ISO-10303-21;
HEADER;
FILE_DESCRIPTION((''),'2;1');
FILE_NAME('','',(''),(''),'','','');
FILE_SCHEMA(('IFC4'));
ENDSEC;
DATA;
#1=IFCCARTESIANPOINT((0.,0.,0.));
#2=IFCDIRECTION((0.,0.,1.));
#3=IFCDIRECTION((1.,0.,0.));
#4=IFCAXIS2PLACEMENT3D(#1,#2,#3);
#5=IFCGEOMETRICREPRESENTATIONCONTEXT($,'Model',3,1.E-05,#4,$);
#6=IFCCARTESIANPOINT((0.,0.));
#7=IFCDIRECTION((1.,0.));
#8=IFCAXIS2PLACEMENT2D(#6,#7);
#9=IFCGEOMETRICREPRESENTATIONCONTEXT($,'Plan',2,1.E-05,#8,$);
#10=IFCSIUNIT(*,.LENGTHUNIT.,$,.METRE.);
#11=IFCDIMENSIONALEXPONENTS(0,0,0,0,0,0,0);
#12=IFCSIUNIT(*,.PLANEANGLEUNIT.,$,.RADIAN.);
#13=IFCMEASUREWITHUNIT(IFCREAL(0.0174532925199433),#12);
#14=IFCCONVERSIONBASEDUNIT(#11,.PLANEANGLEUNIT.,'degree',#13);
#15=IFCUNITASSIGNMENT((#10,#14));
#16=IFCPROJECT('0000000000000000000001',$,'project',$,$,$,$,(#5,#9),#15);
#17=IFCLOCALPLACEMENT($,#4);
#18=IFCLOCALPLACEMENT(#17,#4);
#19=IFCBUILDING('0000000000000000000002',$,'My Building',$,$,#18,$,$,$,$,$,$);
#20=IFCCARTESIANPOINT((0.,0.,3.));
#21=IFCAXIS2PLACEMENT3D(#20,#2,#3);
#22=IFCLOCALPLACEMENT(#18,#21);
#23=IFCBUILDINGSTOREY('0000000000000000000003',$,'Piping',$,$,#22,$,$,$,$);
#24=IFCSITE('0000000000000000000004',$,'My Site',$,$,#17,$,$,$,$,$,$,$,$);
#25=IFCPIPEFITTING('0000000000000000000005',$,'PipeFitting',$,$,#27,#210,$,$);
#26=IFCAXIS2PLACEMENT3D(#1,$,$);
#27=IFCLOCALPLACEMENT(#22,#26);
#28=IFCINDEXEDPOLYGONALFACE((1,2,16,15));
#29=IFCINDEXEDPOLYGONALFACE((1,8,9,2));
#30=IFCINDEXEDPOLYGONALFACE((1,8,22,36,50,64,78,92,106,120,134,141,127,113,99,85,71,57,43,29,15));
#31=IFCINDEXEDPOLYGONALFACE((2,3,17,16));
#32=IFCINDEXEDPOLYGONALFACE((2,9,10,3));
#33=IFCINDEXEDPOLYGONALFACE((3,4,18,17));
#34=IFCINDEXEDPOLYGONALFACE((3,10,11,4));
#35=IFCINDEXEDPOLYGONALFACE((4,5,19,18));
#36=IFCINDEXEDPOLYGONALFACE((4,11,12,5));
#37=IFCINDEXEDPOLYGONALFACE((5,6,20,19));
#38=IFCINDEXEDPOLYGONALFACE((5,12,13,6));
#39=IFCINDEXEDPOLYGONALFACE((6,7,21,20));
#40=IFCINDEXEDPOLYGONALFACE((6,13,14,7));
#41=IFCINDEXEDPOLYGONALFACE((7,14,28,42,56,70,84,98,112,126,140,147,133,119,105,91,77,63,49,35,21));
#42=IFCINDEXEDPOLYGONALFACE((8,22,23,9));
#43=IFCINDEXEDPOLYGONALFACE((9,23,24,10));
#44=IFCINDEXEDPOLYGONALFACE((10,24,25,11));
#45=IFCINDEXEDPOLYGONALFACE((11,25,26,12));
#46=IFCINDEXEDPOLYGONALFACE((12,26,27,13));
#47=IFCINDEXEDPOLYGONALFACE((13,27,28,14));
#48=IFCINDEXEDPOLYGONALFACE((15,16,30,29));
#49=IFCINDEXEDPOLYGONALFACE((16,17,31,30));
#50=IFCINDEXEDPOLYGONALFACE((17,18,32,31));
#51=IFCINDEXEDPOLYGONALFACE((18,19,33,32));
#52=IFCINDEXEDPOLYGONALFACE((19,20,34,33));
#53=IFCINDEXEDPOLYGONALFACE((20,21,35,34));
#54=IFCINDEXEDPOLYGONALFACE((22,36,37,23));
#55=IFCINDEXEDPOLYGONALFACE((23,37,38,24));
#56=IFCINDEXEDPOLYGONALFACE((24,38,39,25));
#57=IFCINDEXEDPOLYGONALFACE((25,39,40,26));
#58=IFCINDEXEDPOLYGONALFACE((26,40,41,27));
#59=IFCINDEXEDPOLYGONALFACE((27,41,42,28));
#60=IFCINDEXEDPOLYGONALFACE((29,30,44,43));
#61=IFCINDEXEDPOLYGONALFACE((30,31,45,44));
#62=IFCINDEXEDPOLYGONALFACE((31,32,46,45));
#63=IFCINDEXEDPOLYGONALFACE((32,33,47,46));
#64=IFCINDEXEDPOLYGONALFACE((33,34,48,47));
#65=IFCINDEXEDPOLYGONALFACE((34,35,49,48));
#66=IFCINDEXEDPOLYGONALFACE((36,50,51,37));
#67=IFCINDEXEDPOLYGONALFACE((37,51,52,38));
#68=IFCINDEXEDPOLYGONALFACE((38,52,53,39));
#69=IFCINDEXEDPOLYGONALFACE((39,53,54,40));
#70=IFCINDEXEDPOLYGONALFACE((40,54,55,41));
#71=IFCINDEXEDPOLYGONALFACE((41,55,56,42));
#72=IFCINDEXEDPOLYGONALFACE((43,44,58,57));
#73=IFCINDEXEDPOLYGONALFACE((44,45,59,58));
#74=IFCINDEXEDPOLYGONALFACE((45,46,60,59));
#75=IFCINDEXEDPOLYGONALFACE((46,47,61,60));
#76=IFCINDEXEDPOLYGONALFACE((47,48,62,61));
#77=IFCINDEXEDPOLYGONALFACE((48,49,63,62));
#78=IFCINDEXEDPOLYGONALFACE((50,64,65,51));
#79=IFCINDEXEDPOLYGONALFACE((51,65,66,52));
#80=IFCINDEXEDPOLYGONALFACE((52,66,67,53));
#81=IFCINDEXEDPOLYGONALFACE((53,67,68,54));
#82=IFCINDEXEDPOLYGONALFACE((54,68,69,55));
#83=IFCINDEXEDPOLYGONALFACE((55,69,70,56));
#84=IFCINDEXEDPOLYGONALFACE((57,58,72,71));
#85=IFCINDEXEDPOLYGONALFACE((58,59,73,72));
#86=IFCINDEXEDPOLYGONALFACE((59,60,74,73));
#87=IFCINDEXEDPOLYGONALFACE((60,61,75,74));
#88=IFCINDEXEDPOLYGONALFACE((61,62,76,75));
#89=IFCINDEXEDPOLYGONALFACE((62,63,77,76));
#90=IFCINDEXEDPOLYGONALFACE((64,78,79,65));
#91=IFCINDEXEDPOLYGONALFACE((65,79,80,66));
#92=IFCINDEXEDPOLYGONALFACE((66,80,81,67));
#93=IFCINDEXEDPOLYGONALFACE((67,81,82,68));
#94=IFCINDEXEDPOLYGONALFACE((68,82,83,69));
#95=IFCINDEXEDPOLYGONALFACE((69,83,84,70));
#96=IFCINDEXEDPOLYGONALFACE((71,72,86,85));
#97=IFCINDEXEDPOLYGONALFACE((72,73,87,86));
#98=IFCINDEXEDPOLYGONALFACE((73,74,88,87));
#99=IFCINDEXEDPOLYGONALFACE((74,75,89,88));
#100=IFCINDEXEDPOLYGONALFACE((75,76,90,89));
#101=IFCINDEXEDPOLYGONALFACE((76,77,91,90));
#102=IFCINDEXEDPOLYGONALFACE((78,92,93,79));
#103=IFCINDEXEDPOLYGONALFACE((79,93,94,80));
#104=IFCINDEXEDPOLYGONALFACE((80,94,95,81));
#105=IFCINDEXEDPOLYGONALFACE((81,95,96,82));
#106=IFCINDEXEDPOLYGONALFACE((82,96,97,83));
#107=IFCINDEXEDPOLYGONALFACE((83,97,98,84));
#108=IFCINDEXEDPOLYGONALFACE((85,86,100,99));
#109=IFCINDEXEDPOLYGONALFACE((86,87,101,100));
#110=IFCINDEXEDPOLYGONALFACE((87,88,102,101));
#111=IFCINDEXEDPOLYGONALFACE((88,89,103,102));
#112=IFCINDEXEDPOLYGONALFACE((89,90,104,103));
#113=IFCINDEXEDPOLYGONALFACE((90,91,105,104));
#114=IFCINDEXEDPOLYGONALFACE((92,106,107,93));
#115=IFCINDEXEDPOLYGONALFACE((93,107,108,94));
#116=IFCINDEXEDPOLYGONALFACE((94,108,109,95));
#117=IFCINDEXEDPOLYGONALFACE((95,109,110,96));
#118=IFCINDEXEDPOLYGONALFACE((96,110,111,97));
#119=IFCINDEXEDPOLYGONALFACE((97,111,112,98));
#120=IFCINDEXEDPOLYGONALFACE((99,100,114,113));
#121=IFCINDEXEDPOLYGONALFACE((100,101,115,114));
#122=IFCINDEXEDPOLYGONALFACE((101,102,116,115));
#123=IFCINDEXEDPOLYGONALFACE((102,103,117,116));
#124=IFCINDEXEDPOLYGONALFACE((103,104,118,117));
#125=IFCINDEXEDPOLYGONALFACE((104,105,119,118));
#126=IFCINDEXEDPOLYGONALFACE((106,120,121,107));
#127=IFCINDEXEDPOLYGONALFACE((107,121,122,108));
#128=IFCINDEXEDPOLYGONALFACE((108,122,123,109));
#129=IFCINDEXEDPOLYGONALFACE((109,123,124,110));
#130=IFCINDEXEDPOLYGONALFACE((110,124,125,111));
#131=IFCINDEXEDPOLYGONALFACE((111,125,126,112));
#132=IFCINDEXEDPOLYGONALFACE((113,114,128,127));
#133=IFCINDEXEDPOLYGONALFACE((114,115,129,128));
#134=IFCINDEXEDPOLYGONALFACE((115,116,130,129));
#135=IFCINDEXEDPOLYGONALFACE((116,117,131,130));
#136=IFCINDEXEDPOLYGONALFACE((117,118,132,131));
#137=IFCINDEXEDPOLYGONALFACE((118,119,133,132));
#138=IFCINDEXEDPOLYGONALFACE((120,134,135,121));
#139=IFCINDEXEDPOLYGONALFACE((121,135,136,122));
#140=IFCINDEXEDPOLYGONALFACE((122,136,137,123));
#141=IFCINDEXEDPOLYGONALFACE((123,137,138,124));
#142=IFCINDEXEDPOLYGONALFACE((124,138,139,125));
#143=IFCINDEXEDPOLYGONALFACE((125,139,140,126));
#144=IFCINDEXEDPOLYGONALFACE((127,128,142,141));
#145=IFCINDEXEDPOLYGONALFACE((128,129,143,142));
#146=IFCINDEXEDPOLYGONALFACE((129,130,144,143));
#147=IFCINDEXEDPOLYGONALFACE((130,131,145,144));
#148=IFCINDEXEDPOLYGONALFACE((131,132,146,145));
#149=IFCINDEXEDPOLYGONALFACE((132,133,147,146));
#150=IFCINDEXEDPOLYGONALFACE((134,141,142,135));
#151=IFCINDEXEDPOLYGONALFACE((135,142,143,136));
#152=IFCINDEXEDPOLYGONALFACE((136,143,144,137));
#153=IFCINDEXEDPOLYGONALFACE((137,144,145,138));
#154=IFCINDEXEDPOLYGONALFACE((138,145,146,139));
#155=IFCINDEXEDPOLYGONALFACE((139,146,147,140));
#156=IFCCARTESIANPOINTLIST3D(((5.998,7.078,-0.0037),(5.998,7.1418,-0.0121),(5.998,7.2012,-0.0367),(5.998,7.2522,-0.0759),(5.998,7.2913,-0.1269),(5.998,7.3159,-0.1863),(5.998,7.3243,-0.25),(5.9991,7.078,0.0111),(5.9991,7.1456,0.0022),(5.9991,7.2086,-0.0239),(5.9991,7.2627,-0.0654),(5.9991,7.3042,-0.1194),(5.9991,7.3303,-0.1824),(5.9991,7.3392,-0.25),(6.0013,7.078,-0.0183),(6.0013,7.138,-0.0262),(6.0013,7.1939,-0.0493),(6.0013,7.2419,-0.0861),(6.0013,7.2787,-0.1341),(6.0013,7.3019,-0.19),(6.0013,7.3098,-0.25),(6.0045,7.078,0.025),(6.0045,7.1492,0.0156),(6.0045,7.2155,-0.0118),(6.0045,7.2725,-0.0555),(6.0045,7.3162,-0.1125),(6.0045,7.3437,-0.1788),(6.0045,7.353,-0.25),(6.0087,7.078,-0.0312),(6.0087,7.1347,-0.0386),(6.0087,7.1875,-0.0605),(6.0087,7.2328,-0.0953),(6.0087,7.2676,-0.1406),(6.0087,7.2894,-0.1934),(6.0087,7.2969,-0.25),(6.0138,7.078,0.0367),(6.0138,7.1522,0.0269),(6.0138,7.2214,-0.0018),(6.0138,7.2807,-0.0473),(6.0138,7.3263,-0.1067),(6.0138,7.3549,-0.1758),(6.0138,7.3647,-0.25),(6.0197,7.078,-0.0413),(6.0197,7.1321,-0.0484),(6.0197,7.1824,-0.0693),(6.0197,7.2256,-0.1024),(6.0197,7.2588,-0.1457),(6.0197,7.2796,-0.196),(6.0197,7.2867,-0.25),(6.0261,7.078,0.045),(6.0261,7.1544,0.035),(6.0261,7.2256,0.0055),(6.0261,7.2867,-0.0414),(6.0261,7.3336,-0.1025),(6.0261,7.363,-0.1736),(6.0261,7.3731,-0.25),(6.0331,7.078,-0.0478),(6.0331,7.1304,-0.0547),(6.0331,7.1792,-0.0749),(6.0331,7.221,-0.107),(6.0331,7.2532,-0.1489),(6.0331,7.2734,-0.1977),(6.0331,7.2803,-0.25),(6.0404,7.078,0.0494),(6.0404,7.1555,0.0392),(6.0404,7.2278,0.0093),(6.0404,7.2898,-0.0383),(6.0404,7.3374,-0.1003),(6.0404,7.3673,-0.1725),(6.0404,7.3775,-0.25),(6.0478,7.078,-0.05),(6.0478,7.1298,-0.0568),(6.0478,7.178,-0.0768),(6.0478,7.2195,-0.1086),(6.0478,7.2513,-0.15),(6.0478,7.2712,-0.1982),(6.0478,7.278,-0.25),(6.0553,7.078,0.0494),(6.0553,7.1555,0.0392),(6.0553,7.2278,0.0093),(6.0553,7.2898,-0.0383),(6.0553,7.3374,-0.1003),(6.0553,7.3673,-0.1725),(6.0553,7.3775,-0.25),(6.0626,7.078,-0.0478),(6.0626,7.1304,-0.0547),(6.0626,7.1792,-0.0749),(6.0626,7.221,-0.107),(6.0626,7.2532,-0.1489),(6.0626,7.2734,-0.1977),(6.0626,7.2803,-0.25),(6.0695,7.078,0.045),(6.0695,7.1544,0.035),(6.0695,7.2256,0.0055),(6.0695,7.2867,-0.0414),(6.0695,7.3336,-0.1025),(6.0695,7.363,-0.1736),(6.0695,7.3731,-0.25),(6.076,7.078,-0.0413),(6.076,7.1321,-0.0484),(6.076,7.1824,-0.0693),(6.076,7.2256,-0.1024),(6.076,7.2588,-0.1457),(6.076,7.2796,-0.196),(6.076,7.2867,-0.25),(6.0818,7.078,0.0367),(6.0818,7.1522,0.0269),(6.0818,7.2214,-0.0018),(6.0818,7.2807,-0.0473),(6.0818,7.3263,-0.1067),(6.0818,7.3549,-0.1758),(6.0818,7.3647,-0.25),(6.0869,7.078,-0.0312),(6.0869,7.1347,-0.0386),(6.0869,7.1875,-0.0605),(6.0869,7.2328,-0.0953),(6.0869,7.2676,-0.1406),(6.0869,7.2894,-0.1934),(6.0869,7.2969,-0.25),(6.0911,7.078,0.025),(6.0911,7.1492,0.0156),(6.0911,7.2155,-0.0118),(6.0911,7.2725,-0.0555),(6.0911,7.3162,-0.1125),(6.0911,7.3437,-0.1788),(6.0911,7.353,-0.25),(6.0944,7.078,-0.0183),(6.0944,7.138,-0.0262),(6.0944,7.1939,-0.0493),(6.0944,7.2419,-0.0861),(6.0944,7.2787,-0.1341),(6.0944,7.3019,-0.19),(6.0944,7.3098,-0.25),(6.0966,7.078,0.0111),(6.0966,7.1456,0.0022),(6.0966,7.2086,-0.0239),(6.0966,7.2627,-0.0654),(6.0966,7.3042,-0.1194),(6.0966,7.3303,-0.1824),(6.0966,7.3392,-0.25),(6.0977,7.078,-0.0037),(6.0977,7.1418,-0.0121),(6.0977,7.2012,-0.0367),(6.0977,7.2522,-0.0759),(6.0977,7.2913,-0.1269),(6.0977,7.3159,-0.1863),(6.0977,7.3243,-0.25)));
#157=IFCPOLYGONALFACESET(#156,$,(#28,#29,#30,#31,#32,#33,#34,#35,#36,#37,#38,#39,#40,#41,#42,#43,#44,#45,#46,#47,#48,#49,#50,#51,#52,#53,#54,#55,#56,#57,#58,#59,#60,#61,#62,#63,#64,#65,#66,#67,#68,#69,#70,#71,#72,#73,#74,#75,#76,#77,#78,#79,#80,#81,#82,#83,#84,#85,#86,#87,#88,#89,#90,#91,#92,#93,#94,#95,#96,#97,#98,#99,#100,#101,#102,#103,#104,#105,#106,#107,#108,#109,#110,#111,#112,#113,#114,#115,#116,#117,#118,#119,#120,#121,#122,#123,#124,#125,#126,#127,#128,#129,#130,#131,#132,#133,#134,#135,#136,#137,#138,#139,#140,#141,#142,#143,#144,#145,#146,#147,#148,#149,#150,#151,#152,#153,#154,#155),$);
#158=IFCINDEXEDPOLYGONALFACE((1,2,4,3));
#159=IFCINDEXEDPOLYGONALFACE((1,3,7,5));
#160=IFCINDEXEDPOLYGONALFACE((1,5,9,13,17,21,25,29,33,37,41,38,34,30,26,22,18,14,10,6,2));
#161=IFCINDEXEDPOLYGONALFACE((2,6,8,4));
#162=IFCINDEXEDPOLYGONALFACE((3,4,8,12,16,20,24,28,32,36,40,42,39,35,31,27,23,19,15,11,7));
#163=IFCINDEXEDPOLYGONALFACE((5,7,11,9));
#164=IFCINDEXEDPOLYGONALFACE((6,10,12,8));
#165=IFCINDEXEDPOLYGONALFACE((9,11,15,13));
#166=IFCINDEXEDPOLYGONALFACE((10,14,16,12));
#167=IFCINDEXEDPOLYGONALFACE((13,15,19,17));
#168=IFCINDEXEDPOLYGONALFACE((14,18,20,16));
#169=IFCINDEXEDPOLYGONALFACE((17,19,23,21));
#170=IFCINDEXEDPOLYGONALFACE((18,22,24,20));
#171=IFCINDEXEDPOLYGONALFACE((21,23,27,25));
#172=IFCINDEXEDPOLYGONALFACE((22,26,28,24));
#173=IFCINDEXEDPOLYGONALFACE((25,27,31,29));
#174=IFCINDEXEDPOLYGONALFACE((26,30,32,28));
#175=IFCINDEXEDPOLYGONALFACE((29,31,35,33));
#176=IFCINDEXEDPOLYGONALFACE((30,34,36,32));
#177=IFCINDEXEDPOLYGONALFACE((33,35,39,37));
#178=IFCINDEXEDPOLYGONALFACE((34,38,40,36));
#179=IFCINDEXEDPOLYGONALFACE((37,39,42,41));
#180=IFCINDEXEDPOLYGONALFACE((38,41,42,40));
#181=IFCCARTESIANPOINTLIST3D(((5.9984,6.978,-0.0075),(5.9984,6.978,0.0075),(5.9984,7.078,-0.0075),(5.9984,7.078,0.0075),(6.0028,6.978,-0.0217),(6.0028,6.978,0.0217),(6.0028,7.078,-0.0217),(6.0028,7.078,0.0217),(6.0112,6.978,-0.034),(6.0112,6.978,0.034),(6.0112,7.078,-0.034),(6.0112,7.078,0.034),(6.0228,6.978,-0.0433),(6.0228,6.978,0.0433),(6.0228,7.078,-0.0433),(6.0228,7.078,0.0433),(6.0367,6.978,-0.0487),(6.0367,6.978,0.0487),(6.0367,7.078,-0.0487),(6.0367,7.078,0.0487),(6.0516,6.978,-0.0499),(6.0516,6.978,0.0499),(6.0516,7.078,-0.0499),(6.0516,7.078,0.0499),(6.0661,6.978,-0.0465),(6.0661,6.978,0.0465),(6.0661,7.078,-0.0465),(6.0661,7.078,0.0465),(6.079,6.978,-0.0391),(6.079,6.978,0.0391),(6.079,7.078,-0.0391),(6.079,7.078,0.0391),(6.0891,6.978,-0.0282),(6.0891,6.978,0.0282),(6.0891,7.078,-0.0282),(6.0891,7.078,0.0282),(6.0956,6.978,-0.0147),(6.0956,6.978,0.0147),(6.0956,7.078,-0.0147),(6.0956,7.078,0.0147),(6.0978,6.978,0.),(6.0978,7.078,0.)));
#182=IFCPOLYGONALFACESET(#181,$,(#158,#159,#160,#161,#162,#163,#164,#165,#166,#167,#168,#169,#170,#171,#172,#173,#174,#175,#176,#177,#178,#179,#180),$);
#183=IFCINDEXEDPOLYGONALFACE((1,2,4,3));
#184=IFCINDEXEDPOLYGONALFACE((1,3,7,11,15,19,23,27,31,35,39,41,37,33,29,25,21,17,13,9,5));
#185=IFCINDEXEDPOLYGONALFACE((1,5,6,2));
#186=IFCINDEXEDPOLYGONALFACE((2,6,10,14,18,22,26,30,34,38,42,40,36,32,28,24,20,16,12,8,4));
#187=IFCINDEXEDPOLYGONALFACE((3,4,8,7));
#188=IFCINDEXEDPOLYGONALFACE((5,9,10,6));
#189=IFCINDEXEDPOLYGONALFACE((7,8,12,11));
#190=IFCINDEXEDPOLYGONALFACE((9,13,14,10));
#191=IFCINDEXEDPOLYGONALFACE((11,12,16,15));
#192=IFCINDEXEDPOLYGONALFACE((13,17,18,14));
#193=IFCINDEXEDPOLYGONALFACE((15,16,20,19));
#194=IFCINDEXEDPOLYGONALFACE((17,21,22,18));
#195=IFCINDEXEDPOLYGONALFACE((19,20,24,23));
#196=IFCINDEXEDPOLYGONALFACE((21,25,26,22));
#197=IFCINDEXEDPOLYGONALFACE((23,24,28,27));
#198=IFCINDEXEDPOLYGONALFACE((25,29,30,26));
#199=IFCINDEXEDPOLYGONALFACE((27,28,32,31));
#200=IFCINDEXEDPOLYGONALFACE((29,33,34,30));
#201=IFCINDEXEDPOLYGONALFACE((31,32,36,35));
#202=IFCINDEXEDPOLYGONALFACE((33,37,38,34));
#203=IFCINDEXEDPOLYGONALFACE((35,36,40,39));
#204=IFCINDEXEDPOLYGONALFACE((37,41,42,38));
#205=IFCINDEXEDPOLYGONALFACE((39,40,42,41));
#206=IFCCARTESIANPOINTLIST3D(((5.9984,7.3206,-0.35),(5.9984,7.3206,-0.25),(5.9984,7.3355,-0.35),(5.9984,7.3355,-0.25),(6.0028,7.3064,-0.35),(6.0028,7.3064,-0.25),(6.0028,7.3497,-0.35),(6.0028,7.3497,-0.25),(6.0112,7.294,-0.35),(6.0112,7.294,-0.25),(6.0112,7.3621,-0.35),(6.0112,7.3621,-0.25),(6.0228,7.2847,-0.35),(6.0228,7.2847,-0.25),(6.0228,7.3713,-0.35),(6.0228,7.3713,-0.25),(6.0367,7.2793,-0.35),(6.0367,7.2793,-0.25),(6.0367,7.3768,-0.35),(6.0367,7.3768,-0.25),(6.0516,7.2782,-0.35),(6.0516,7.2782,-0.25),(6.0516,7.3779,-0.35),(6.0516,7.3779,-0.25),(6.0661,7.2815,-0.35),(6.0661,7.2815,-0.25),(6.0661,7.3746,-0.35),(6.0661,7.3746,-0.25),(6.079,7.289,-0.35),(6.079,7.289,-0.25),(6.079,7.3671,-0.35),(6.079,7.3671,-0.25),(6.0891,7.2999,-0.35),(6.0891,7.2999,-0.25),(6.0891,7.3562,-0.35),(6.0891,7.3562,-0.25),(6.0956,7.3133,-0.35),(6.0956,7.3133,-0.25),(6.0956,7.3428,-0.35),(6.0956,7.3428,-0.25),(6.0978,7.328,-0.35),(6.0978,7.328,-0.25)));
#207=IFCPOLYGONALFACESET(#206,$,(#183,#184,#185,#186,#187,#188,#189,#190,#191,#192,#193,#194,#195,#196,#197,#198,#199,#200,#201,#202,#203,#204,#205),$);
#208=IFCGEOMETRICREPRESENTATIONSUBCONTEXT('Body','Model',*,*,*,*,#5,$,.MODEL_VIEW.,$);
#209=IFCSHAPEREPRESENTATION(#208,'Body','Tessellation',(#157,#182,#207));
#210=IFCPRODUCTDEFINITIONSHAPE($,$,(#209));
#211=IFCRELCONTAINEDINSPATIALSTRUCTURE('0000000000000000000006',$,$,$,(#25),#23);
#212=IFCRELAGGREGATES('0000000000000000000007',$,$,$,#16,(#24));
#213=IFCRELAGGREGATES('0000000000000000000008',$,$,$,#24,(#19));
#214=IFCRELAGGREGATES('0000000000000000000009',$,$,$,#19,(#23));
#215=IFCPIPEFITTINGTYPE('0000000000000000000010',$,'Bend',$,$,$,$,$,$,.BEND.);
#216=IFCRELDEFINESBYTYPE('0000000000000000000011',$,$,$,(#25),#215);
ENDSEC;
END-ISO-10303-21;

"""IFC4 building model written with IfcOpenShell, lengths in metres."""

from ifc_helpers import new_model, entity, si_unit, converted_unit, frame, origin_with_axes, origin_2d_with_axis, place, context, subcontext, project, spatial, circle, extrude, source, transform, mapped, type_object, type_shapes, element, save


model = new_model("IFC4")

# Units and contexts
model_context = context("Model", 3, precision=1e-05, world=origin_with_axes())
plan_context = context("Plan", 2, precision=1e-05, world=origin_2d_with_axis())
body_context = subcontext(model_context, "Body", "Model", "MODEL_VIEW")
ifc_project = project(units=[si_unit("LENGTHUNIT", "METRE"), converted_unit("PLANEANGLEUNIT", "degree", entity("IfcReal", 0.0174532925199433), si_unit("PLANEANGLEUNIT", "RADIAN"), dimensions=[0, 0, 0, 0, 0, 0, 0])], contexts=[model_context, plan_context])

# Site, building, storey
site_placement = place(None, origin_with_axes())
site = spatial("IfcSite", under=ifc_project, at=site_placement, Name="My Site")
building_placement = place(site_placement, origin_with_axes())
building = spatial("IfcBuilding", under=site, at=building_placement, Name="My Building")
storey_placement = place(building_placement, frame((0.0, 0.0, 3.0), z_axis=(0.0, 0.0, 1.0), x_axis=(1.0, 0.0, 0.0)))
storey = spatial("IfcBuildingStorey", under=building, at=storey_placement, Name="Piping")

# Pipe fitting
pipe_fitting_type_1 = type_object("IfcPipeFittingType", Name="Bend", PredefinedType="BEND")
shared_shape = source(origin_with_axes(), body_context, "Body", "SolidModel", [
    entity("IfcSweptDiskSolid", entity("IfcIndexedPolyCurve", entity("IfcCartesianPointList3D", [[0.0, 0.0, -0.1], [0.0, -0.0732, -0.2768], [0.0, -0.25, -0.35]]), [entity("IfcArcIndex", [1, 2, 3])]), 0.05),
    extrude(circle(Radius=0.05), origin_with_axes(), (0.0, 0.0, -1.0), 0.1),
    extrude(circle(Radius=0.05), frame((0.0, -0.25, -0.35), z_axis=(0.0, -1.0, 0.0), x_axis=(1.0, 0.0, 0.0)), (0.0, 0.0, 1.0), 0.1),
])
type_shapes(pipe_fitting_type_1, [shared_shape])
for number, where, z_axis, x_axis, name in (
    (1, (6.0478, 6.978, 0.0), (0.0, -1.0, 0.0), (1.0, 0.0, 0.0), "PipeFitting"),
):
    element("IfcPipeFitting", number, at=place(storey_placement, frame(where, z_axis=z_axis, x_axis=x_axis)), inside=storey, type_object=pipe_fitting_type_1, Name=name, context=body_context, shape_type="MappedRepresentation", body=[
        mapped(shared_shape, transform((0.0, 0.0, 0.0), x_axis=(1.0, 0.0, 0.0), y_axis=(0.0, 1.0, 0.0), z_axis=(0.0, 0.0, 1.0), scale=1.0)),
    ])

save(model, "model.ifc")
